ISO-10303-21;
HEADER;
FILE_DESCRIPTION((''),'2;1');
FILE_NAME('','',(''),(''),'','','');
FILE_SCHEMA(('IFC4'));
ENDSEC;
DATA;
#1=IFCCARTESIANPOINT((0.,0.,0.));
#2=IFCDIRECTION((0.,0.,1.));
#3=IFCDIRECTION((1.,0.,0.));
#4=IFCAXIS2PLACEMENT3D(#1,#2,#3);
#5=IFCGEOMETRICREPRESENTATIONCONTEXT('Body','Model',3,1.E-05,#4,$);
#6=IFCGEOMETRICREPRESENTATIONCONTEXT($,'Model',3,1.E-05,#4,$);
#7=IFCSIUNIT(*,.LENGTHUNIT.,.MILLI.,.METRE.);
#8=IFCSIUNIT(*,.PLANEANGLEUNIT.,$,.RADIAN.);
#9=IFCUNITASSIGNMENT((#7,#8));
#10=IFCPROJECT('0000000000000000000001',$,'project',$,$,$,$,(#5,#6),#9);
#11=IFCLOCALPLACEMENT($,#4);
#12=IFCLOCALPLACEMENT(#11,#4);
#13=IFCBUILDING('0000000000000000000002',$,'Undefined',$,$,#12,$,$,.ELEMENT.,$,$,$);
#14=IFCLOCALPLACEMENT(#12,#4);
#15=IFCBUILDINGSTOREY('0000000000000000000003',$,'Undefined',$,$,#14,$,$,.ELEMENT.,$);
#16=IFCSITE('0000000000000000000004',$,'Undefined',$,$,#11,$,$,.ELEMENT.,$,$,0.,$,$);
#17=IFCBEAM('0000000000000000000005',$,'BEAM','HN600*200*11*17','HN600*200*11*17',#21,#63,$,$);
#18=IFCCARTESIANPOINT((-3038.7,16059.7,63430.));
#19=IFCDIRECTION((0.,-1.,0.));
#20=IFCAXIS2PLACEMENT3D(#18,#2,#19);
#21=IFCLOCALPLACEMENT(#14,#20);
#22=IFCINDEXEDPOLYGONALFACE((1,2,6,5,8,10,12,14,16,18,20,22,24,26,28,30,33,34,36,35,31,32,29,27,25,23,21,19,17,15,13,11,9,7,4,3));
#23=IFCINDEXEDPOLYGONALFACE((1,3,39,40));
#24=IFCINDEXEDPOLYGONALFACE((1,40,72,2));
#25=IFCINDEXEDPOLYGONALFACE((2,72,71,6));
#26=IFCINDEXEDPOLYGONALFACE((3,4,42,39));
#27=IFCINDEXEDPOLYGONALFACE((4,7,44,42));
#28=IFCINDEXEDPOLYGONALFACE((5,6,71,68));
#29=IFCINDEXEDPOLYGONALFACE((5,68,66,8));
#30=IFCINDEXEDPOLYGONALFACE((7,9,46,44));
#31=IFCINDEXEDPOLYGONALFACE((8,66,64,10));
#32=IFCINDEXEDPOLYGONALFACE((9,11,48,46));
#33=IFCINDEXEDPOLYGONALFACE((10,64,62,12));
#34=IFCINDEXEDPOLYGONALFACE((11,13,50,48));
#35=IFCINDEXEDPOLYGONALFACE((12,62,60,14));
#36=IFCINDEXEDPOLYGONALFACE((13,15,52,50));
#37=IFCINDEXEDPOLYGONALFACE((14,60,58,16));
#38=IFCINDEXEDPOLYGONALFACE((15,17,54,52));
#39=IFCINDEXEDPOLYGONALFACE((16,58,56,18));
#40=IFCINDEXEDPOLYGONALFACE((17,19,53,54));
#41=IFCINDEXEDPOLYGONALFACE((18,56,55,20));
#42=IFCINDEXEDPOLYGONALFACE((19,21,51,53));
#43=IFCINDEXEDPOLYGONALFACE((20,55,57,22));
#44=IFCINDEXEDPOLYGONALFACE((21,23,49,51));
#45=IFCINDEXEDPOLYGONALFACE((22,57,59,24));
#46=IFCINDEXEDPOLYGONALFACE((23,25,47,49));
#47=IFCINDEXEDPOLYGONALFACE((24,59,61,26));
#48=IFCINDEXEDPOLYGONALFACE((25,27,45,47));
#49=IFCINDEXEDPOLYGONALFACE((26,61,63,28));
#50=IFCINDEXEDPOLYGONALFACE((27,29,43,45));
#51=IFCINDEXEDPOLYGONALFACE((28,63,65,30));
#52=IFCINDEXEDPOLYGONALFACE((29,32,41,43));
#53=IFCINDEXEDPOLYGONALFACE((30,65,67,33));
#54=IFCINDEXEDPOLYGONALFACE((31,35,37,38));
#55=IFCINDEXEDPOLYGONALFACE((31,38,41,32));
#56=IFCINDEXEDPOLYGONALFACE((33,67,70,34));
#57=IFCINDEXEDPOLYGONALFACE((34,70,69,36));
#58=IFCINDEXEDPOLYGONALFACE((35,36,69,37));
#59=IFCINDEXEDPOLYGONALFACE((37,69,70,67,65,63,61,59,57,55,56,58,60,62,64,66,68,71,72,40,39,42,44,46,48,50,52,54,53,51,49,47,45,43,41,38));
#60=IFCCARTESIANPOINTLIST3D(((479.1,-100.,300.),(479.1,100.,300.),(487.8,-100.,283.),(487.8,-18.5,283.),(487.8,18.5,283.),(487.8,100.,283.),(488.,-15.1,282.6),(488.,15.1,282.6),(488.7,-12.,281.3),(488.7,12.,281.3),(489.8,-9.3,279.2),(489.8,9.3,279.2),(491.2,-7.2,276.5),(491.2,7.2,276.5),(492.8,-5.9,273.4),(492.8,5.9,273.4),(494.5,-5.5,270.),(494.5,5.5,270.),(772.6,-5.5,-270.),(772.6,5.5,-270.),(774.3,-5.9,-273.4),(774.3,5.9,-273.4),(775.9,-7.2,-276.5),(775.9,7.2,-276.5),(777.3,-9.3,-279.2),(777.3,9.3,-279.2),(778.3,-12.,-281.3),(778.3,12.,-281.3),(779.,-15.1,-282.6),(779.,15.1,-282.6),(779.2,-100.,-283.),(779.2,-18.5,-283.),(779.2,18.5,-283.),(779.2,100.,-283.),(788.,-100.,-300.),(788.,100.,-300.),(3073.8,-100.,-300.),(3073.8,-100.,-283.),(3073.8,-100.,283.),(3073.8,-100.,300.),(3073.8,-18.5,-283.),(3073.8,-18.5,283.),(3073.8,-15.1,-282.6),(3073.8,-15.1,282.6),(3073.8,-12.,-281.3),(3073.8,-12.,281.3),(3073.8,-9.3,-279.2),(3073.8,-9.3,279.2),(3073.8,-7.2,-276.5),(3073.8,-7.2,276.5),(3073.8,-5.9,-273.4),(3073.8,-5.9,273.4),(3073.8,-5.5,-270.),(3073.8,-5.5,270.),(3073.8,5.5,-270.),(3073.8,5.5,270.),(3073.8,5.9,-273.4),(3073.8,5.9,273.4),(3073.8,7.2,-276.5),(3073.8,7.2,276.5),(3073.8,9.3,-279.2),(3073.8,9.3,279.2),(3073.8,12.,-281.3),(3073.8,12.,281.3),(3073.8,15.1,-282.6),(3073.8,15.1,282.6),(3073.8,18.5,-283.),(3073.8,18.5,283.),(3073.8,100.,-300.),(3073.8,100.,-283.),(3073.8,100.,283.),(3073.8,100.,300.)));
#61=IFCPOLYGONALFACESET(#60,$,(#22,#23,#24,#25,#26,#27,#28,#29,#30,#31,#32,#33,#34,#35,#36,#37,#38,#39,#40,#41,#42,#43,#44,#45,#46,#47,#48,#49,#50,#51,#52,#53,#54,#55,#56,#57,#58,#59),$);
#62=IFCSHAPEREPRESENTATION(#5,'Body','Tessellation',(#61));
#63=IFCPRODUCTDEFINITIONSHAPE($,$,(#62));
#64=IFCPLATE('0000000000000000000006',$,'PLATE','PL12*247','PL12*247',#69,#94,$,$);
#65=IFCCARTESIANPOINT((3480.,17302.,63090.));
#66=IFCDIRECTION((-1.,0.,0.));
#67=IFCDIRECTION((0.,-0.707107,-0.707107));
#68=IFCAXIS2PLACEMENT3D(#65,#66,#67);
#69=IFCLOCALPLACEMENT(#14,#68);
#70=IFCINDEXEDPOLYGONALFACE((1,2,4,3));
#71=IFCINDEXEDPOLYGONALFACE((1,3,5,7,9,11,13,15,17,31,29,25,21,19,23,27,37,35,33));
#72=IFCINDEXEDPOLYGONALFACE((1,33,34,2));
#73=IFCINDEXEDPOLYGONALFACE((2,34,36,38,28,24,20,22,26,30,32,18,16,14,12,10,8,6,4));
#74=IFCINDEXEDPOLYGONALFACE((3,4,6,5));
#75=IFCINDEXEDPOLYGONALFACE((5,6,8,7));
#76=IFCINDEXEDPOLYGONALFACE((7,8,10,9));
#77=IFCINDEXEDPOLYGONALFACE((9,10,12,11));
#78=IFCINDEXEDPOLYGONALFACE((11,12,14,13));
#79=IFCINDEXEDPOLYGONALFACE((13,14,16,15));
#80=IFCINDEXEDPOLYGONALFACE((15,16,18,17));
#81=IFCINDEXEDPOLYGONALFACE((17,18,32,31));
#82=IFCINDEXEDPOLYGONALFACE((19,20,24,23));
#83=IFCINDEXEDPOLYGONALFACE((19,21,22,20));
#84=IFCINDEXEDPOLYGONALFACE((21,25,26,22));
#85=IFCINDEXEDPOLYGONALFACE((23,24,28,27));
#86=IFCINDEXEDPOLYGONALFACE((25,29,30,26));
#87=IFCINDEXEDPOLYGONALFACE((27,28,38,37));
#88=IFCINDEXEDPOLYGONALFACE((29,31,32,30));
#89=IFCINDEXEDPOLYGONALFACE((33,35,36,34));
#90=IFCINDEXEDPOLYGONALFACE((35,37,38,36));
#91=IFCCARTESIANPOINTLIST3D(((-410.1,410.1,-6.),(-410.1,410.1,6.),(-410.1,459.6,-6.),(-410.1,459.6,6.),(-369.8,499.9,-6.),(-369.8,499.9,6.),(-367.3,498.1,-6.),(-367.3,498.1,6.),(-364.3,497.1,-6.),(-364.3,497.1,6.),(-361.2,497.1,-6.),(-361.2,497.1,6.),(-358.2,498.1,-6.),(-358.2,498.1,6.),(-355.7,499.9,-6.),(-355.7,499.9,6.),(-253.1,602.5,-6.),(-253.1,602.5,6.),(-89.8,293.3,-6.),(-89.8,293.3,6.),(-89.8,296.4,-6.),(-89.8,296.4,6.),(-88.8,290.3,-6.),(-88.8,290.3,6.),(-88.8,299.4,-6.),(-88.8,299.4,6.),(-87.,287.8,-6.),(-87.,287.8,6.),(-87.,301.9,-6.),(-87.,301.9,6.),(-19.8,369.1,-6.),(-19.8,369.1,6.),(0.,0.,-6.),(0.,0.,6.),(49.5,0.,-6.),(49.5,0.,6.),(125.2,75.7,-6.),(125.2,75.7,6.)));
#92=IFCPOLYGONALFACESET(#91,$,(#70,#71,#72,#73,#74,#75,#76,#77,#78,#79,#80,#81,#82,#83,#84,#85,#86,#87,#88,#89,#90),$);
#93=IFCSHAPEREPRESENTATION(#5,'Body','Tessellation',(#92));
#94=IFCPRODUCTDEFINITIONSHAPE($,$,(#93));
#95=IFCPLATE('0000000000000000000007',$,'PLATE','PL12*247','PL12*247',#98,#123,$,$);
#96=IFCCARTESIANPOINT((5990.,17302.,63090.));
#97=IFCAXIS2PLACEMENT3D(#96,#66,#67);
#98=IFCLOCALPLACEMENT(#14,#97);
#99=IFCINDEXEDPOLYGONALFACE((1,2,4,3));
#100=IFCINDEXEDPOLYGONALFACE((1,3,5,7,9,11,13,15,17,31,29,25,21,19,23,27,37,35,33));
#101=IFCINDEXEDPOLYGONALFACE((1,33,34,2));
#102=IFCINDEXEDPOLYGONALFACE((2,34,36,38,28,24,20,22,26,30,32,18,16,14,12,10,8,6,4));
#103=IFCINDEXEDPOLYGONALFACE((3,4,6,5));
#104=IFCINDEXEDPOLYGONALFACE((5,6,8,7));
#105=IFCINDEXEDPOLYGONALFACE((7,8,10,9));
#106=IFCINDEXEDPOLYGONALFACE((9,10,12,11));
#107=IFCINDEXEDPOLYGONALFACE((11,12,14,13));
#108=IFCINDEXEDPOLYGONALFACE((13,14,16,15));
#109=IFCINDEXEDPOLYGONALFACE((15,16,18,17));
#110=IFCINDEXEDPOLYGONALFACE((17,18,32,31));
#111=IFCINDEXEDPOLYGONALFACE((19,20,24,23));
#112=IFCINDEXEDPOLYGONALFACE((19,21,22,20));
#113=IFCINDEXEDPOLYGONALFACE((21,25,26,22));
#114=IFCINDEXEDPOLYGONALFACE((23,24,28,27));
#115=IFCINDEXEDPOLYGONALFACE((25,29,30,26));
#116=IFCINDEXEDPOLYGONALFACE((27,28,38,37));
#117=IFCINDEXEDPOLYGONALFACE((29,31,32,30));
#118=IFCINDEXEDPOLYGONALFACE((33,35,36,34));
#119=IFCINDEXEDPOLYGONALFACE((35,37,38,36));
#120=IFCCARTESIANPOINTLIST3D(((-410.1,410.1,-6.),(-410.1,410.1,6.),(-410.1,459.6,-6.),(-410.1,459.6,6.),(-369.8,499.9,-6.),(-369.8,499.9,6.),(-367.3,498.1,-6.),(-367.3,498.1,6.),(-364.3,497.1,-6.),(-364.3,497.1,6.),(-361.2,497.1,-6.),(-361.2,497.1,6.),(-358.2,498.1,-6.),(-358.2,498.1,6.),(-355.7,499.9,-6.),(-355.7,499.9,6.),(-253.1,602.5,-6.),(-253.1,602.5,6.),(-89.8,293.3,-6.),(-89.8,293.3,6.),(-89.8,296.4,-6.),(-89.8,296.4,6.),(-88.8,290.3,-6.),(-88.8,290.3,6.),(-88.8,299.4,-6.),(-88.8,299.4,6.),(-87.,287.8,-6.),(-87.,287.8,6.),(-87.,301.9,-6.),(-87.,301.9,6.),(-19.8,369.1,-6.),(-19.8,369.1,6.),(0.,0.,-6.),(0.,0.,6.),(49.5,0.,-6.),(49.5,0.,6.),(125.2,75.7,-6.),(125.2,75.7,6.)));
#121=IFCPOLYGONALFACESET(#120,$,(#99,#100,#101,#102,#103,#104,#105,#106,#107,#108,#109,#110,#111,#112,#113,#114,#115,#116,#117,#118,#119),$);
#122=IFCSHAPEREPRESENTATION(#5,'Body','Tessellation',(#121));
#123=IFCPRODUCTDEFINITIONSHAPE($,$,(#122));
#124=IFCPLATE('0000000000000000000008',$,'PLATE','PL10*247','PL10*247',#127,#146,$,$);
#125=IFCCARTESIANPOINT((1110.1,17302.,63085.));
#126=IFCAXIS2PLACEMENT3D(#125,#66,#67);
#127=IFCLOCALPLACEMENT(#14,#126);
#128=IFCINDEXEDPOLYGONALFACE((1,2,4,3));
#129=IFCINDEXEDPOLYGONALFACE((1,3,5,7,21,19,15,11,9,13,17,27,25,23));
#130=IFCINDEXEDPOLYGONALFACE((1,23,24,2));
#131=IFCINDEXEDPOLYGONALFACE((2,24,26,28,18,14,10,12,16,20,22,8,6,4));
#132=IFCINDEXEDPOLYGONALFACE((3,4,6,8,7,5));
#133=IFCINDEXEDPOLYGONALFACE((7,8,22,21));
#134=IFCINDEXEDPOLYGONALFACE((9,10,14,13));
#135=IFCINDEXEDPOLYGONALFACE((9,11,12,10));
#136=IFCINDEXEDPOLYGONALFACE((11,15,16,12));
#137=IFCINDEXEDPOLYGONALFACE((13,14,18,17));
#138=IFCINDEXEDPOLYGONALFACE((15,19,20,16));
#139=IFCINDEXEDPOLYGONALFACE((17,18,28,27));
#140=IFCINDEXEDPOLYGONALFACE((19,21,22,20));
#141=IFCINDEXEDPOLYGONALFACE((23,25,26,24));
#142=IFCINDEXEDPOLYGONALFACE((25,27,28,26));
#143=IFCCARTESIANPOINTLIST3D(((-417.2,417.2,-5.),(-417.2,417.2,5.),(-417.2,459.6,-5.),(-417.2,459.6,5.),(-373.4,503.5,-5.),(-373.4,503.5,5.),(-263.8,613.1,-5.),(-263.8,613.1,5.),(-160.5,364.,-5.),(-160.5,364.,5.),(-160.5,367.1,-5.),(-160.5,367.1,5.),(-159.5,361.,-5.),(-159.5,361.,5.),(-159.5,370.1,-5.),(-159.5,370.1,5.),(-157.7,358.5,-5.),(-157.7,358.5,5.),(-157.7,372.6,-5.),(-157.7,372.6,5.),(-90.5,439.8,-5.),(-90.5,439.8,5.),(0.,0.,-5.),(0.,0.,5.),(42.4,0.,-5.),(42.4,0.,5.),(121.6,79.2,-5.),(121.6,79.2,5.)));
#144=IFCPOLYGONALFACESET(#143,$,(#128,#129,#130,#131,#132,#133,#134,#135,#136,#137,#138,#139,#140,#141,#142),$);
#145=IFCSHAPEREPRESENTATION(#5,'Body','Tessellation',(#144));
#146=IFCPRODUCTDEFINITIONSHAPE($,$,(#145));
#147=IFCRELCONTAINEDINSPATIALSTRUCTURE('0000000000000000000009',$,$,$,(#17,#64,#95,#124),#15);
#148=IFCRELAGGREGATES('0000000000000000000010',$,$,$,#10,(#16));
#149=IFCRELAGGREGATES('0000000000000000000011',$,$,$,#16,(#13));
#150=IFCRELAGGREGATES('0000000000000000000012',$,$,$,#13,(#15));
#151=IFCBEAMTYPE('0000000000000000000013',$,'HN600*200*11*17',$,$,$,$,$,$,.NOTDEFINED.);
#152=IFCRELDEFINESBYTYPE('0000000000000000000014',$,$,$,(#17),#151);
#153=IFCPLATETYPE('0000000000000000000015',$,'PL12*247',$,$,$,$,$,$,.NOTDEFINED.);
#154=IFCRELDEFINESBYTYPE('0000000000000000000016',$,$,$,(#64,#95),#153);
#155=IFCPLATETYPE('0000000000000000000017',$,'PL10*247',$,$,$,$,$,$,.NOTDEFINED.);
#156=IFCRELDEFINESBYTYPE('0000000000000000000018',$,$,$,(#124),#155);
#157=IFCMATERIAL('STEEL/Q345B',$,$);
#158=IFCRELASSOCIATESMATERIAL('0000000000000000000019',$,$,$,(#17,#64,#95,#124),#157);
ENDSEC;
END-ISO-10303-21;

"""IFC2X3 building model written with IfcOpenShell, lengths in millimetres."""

from ifc_helpers import new_model, si_unit, frame, origin_with_axes, origin_2d_with_axis, place, context, project, spatial, polyline, i_section, outline, extrude, clip, halfspace, material, type_object, element, save


model = new_model("IFC2X3")

# Units and contexts
model_context_1 = context("Model", 3, precision=1e-05, world=origin_with_axes(), identifier="Body")
model_context_2 = context("Model", 3, precision=1e-05, world=origin_with_axes())
ifc_project = project(units=[si_unit("LENGTHUNIT", "METRE", prefix="MILLI"), si_unit("PLANEANGLEUNIT", "RADIAN")], contexts=[model_context_1, model_context_2])

# Site, building, storey
site_placement = place(None, origin_with_axes())
site = spatial("IfcSite", under=ifc_project, at=site_placement, Name="Undefined", CompositionType="ELEMENT", RefElevation=0.0)
building_placement = place(site_placement, origin_with_axes())
building = spatial("IfcBuilding", under=site, at=building_placement, Name="Undefined", CompositionType="ELEMENT")
storey_placement = place(building_placement, origin_with_axes())
storey = spatial("IfcBuildingStorey", under=building, at=storey_placement, Name="Undefined", CompositionType="ELEMENT")

# Shared definitions
ifc_material_1 = material(Name="STEEL/Q345B")

# Beam
beam_type_1 = type_object("IfcBeamType", Name="HN600*200*11*17", PredefinedType="NOTDEFINED")
beam_1_placement = place(storey_placement, frame((-3038.7, 16059.7, 63430.0), z_axis=(0.0, 0.0, 1.0), x_axis=(0.0, -1.0, 0.0)))
element("IfcBeam", 1, at=beam_1_placement, inside=storey, type_object=beam_type_1, material=ifc_material_1, Name="BEAM", Description="HN600*200*11*17", ObjectType="HN600*200*11*17", context=model_context_1, shape_type="Clipping", body=[
    clip(clip(extrude(i_section(OverallWidth=200.0, OverallDepth=600.0, WebThickness=11.0, FlangeThickness=17.0, FilletRadius=13.0, at=origin_2d_with_axis()), frame((3073.8, 0.0, 0.0), z_axis=(-1.0, 0.0, 0.0), x_axis=(0.0, -1.0, 0.0)), (0.0, 0.0, 1.0), 2596.3), halfspace(frame((487.8, 0.0, 283.0), z_axis=(-0.88907, 0.0, -0.457771), x_axis=(0.457771, 0.0, -0.88907)), False)), halfspace(frame((3073.8, 0.0, -71.8), z_axis=(1.0, 0.0, 0.0), x_axis=(0.0, -1.0, 0.0)), False)),
])

# Plates
plate_type_1 = type_object("IfcPlateType", Name="PL12*247", PredefinedType="NOTDEFINED")
for number, where, z_axis, x_axis, name in (
    (2, (3480.0, 17302.0, 63090.0), (-1.0, 0.0, 0.0), (0.0, -0.707107, -0.707107), "PLATE"),
    (3, (5990.0, 17302.0, 63090.0), (-1.0, 0.0, 0.0), (0.0, -0.707107, -0.707107), "PLATE"),
):
    element("IfcPlate", number, at=place(storey_placement, frame(where, z_axis=z_axis, x_axis=x_axis)), inside=storey, type_object=plate_type_1, material=ifc_material_1, Name=name, Description="PL12*247", ObjectType="PL12*247", context=model_context_1, shape_type="SweptSolid", body=[
        extrude(outline(polyline([(0.0, 0.0), (49.5, 0.0), (125.2, 75.7), (-87.0, 287.8), (-88.8, 290.3), (-89.8, 293.3), (-89.8, 296.4), (-88.8, 299.4), (-87.0, 301.9), (-19.8, 369.1), (-253.1, 602.5), (-355.7, 499.9), (-358.2, 498.1), (-361.2, 497.1), (-364.3, 497.1), (-367.3, 498.1), (-369.8, 499.9), (-410.1, 459.6), (-410.1, 410.1), (0.0, 0.0)])), frame((0.0, 0.0, -6.0), z_axis=(0.0, 0.0, 1.0), x_axis=(1.0, 0.0, 0.0)), (0.0, 0.0, 1.0), 12.0),
    ])
plate_type_2 = type_object("IfcPlateType", Name="PL10*247", PredefinedType="NOTDEFINED")
plate_1_placement = place(storey_placement, frame((1110.1, 17302.0, 63085.0), z_axis=(-1.0, 0.0, 0.0), x_axis=(0.0, -0.707107, -0.707107)))
element("IfcPlate", 4, at=plate_1_placement, inside=storey, type_object=plate_type_2, material=ifc_material_1, Name="PLATE", Description="PL10*247", ObjectType="PL10*247", context=model_context_1, shape_type="SweptSolid", body=[
    extrude(outline(polyline([(0.0, 0.0), (42.4, 0.0), (121.6, 79.2), (-157.7, 358.5), (-159.5, 361.0), (-160.5, 364.0), (-160.5, 367.1), (-159.5, 370.1), (-157.7, 372.6), (-90.5, 439.8), (-263.8, 613.1), (-373.4, 503.5), (-417.2, 459.6), (-417.2, 417.2), (0.0, 0.0)])), frame((0.0, 0.0, -5.0), z_axis=(0.0, 0.0, 1.0), x_axis=(1.0, 0.0, 0.0)), (0.0, 0.0, 1.0), 10.0),
])

save(model, "model.ifc")
